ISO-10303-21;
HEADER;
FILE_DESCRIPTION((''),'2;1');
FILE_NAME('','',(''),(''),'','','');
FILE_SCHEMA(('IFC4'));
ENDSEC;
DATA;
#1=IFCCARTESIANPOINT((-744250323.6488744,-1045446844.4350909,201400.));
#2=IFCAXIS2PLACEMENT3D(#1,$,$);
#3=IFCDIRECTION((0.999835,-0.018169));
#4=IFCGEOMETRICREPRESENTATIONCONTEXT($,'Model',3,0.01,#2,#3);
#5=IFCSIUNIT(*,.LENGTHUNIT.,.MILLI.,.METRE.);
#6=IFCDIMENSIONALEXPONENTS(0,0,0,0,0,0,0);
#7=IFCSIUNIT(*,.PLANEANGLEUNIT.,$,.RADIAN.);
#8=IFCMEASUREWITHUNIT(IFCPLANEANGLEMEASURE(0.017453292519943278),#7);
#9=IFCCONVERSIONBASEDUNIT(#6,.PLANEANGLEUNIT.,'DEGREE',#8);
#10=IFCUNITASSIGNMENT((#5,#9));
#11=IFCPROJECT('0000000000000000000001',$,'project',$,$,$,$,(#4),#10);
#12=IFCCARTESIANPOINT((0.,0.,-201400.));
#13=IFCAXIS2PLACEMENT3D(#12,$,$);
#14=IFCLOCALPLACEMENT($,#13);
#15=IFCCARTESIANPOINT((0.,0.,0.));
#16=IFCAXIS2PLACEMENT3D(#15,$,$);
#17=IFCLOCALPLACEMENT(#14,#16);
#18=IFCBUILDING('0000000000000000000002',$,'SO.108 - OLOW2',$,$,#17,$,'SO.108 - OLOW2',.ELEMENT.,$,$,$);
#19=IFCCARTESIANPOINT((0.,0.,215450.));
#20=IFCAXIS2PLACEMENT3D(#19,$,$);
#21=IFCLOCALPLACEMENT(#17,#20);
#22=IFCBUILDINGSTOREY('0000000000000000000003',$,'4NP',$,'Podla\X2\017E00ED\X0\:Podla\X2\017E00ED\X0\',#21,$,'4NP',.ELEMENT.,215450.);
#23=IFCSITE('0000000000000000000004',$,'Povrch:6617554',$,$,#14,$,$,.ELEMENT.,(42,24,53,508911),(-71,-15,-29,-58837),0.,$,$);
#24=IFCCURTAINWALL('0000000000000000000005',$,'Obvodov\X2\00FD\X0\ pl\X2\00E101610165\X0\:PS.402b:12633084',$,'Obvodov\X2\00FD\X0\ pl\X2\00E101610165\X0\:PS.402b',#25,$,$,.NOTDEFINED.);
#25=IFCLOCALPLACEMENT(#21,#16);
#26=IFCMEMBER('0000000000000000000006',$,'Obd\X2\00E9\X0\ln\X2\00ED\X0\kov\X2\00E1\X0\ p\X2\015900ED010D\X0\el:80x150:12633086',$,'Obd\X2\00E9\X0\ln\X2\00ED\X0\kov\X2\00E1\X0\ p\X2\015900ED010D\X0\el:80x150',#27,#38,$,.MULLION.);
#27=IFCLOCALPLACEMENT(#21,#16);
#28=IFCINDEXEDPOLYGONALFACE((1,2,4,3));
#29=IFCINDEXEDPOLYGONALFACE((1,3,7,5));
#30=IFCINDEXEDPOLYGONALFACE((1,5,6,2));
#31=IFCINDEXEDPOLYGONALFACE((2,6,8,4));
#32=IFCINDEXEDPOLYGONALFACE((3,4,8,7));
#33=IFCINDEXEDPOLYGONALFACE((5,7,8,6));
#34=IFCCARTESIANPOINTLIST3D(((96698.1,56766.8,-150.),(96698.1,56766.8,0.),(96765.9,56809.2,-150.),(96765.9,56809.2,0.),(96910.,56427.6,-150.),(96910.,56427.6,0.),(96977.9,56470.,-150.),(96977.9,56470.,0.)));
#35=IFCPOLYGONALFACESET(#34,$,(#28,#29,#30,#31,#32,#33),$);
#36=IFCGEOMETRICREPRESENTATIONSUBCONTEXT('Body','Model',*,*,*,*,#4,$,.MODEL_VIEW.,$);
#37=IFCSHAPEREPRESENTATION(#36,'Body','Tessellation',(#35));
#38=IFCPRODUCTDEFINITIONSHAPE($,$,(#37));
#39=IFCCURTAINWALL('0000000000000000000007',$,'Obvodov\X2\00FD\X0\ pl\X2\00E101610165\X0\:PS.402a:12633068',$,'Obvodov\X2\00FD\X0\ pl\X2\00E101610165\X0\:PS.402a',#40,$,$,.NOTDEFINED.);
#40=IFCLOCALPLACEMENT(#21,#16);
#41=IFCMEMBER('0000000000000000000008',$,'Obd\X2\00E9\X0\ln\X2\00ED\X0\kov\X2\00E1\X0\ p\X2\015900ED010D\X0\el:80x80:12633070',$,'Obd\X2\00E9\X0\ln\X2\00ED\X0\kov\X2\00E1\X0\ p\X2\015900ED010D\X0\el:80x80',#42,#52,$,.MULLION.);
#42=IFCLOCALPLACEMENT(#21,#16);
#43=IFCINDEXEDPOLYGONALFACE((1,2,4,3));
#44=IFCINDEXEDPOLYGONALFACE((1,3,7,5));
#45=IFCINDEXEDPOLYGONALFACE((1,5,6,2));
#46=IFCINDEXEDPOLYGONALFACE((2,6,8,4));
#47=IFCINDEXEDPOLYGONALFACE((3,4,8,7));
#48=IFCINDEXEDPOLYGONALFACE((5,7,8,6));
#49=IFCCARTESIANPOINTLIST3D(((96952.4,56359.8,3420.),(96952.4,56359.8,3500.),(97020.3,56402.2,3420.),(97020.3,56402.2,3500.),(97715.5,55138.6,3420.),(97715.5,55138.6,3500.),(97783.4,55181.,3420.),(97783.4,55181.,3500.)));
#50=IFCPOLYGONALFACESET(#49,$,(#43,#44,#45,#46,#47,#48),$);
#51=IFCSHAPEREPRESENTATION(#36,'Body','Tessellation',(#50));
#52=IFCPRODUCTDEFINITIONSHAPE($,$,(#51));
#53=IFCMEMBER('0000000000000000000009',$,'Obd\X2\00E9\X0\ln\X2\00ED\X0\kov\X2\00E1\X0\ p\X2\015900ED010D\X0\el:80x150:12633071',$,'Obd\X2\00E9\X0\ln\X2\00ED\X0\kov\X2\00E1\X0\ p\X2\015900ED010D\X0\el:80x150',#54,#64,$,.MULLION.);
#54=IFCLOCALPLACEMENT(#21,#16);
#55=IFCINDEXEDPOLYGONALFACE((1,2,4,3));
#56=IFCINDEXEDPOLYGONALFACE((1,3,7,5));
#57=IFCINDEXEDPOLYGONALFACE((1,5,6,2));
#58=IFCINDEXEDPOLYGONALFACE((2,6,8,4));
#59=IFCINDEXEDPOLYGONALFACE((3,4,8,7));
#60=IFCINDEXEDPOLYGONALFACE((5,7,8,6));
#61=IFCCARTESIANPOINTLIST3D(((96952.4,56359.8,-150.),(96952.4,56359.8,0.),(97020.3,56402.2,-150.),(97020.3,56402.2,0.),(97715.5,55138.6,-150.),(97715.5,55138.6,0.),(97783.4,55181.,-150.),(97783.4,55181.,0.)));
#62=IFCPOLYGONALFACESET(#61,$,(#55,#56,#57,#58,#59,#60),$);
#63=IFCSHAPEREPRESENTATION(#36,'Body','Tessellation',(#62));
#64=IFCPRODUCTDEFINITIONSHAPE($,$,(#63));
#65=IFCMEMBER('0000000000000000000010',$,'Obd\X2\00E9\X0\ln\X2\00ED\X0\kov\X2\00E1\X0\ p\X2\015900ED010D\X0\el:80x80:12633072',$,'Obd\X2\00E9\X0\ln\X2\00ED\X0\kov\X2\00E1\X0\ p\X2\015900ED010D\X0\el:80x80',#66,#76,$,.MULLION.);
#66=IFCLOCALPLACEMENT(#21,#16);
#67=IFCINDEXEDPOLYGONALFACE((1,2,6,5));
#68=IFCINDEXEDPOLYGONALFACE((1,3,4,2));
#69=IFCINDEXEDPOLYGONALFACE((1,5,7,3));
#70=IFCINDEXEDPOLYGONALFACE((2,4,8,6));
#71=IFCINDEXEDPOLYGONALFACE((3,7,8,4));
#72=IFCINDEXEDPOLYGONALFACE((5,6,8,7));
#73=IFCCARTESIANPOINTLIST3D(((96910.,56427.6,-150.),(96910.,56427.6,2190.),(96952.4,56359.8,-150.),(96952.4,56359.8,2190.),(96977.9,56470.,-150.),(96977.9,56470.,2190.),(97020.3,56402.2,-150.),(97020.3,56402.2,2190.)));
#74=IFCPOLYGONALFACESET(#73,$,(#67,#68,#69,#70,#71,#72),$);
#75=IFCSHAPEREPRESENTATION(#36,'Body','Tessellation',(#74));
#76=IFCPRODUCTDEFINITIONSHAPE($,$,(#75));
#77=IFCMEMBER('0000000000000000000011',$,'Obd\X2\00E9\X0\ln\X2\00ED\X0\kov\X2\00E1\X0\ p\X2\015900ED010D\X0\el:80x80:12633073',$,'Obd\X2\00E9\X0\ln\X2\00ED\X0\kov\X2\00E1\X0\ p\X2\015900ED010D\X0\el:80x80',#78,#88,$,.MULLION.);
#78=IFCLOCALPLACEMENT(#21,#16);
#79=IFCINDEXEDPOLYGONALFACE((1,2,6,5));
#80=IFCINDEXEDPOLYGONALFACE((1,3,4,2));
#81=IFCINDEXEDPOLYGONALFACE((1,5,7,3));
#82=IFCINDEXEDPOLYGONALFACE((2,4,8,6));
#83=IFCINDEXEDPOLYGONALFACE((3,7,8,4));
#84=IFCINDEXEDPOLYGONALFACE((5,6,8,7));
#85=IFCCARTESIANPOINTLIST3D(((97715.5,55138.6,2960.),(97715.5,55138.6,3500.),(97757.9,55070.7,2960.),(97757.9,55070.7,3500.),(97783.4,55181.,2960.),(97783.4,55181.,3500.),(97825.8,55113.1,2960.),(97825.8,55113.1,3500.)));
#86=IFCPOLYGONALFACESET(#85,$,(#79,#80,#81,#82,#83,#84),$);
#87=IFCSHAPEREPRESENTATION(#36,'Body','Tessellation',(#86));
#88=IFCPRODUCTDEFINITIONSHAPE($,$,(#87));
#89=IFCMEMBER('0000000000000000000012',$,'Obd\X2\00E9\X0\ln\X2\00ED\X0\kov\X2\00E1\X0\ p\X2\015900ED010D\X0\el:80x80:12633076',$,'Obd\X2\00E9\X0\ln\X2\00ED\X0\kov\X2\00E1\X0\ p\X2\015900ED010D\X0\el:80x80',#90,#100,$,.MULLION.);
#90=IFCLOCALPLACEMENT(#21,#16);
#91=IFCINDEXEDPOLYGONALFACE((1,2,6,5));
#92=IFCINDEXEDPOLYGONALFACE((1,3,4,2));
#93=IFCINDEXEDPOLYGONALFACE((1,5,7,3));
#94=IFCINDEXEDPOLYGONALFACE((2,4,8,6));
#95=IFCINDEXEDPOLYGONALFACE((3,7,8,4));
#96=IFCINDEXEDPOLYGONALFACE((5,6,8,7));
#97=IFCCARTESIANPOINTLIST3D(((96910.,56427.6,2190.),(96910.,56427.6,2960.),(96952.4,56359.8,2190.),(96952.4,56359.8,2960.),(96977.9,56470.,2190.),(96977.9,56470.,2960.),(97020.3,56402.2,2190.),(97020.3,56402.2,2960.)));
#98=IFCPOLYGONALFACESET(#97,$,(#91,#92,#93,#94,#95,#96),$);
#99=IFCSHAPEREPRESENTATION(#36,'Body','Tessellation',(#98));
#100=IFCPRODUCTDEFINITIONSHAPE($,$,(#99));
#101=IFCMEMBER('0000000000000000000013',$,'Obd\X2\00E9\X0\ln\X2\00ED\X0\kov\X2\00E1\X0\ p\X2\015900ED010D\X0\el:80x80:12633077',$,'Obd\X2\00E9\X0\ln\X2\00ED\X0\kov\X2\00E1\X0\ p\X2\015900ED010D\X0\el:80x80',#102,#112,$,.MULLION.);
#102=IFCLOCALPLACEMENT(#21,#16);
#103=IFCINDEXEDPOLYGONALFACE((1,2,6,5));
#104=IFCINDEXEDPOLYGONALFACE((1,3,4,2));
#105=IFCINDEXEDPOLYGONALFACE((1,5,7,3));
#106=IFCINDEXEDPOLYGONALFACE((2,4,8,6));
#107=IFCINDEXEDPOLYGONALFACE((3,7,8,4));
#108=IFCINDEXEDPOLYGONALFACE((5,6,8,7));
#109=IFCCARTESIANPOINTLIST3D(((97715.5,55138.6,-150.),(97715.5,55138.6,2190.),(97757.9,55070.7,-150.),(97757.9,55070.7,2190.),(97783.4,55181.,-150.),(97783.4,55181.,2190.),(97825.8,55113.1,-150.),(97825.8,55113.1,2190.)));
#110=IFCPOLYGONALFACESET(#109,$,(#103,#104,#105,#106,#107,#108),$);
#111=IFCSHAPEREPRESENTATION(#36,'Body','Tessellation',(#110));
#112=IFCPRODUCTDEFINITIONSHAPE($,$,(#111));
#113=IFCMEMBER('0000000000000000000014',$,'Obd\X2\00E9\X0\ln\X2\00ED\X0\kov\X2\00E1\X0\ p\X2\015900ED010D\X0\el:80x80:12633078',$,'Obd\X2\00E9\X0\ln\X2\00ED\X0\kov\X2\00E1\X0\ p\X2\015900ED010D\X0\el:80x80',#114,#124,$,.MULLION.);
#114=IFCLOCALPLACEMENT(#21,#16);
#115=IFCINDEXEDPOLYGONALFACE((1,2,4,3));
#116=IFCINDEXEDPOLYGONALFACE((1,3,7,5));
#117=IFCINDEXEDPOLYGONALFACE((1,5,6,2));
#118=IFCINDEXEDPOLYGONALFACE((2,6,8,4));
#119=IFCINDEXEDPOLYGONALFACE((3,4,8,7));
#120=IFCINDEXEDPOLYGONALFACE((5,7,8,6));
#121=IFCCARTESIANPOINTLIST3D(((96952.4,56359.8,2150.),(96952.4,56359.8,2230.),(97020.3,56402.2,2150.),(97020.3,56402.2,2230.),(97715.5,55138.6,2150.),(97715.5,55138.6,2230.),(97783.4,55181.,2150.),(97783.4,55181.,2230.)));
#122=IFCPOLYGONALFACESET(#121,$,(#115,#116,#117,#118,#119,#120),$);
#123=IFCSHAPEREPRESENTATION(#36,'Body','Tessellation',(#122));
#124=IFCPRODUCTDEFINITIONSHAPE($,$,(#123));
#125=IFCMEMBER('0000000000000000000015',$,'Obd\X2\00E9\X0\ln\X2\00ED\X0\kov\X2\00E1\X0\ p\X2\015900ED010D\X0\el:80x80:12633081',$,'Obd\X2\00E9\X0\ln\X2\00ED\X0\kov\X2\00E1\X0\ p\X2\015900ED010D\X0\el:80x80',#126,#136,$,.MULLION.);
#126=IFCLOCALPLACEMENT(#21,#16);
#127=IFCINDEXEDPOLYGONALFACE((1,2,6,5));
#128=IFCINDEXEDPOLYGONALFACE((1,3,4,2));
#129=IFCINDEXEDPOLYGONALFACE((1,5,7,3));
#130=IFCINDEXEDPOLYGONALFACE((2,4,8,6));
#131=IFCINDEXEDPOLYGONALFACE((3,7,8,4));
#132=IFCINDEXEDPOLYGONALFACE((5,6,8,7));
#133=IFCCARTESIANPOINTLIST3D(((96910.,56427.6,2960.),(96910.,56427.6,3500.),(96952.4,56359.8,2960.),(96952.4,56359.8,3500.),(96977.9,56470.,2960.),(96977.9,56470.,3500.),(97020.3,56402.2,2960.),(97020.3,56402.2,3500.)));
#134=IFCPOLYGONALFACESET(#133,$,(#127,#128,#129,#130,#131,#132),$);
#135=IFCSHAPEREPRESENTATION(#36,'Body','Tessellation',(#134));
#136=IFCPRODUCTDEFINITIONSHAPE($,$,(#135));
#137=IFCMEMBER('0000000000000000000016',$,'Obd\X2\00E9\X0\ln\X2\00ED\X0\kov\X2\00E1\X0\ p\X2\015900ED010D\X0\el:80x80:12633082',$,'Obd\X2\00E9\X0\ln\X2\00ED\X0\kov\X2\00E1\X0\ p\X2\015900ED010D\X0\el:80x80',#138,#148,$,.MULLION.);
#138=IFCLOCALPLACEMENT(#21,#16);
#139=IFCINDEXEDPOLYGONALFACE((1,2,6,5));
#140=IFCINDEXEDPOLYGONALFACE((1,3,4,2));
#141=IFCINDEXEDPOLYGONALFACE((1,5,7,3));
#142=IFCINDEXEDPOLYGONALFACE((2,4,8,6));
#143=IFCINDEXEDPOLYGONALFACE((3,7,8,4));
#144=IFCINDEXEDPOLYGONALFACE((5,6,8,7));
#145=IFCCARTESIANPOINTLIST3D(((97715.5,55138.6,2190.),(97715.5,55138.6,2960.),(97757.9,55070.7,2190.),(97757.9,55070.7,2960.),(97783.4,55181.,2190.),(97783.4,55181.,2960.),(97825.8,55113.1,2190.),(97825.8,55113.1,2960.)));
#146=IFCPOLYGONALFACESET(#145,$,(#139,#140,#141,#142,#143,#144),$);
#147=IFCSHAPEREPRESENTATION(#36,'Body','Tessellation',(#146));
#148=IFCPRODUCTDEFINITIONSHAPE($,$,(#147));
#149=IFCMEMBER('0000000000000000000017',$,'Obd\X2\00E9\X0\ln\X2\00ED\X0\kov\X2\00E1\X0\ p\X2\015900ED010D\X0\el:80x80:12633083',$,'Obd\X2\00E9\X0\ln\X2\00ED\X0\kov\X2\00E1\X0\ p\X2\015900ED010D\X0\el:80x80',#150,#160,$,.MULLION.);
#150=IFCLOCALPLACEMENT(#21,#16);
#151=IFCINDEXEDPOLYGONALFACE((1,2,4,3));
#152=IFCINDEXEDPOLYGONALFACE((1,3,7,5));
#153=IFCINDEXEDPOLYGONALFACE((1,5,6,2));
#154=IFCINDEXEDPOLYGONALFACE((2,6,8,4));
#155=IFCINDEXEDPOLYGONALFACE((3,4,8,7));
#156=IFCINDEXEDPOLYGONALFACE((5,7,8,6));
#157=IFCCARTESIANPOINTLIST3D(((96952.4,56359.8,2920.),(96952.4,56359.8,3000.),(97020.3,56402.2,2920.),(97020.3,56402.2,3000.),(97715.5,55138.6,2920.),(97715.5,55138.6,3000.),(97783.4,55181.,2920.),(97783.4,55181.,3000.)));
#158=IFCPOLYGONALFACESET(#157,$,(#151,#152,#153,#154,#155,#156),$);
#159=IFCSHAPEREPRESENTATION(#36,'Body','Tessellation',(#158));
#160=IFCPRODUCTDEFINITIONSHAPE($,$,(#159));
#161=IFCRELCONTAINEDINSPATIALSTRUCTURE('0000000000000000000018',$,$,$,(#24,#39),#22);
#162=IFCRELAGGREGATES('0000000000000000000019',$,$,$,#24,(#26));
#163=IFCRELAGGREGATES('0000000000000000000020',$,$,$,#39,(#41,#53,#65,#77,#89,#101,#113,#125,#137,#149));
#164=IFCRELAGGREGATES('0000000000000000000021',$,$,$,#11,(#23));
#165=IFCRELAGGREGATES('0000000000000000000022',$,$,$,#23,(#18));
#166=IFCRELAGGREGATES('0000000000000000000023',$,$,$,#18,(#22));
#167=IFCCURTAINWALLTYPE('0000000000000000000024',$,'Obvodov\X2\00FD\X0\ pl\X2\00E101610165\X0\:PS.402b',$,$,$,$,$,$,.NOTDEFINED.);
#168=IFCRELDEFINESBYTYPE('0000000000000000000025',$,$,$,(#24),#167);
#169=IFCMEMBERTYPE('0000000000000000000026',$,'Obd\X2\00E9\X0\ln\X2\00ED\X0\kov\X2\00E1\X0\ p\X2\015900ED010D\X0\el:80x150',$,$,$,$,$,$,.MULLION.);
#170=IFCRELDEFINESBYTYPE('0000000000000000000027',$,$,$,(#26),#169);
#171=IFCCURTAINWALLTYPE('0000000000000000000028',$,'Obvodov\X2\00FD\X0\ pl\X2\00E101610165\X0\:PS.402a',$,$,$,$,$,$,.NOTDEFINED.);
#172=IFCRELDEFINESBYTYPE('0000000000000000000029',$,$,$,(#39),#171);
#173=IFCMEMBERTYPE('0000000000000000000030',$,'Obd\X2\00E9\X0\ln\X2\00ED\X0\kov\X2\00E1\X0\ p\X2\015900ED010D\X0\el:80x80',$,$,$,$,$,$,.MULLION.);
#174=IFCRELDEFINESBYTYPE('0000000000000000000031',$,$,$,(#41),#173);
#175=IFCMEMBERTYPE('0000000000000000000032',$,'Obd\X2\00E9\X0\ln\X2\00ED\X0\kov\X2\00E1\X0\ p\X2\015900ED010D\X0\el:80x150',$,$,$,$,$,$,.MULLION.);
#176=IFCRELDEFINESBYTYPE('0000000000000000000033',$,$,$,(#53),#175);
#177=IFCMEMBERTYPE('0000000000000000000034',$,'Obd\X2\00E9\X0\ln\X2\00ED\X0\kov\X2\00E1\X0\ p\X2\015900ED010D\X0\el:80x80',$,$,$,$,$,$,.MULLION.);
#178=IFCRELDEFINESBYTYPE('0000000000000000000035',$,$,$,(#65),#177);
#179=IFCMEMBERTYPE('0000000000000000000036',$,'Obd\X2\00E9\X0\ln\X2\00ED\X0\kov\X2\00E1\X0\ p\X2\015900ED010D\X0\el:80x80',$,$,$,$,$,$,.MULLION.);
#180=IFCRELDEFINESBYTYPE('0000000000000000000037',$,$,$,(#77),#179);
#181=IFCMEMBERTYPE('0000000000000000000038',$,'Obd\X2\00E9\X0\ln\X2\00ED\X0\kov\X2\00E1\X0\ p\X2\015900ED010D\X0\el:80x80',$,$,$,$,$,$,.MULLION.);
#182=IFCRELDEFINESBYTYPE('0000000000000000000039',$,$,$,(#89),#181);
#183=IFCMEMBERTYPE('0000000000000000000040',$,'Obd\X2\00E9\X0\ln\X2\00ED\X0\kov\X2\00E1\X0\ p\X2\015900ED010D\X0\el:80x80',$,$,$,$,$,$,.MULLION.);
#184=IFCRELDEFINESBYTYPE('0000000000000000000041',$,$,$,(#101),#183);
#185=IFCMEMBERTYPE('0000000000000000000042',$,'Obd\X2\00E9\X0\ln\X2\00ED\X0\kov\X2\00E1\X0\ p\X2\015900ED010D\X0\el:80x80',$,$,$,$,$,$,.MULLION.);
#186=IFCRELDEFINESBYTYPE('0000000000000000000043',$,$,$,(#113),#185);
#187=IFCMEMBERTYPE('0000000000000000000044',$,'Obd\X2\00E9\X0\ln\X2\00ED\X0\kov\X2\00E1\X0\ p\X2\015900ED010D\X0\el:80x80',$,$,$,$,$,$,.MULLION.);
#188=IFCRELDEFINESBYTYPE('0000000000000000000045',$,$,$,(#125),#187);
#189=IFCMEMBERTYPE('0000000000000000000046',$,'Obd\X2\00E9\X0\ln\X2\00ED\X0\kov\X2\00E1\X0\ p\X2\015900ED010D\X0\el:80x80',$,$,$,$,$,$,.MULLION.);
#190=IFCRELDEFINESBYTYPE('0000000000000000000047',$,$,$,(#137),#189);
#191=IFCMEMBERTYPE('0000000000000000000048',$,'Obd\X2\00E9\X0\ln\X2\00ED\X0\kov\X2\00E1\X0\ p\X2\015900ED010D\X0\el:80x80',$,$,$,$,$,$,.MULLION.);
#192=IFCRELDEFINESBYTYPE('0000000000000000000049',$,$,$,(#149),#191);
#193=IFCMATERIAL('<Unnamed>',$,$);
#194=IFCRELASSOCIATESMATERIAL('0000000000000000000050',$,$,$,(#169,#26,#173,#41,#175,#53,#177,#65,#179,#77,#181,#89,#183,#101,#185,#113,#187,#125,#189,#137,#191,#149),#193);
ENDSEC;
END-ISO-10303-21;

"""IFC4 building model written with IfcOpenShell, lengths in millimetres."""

from ifc_helpers import new_model, entity, si_unit, converted_unit, direction, frame, origin, place, context, subcontext, project, spatial, indexed_curve, outline, extrude, source, transform, mapped, material, type_object, type_shapes, element, aggregate, save


model = new_model("IFC4")

# Units and contexts
model_context = context("Model", 3, precision=0.01, world=frame((-744250323.6488744, -1045446844.4350909, 201400.0)), true_north=direction((0.999835, -0.018169)))
body_context = subcontext(model_context, "Body", "Model", "MODEL_VIEW")
ifc_project = project(units=[si_unit("LENGTHUNIT", "METRE", prefix="MILLI"), converted_unit("PLANEANGLEUNIT", "DEGREE", entity("IfcPlaneAngleMeasure", 0.017453292519943278), si_unit("PLANEANGLEUNIT", "RADIAN"), dimensions=[0, 0, 0, 0, 0, 0, 0])], contexts=[model_context])

# Site, building, storey
site_placement = place(None, frame((0.0, 0.0, -201400.0)))
site = spatial("IfcSite", under=ifc_project, at=site_placement, Name="Povrch:6617554", CompositionType="ELEMENT", RefLatitude=(42, 24, 53, 508911), RefLongitude=(-71, -15, -29, -58837), RefElevation=0.0)
building_placement = place(site_placement, origin())
building = spatial("IfcBuilding", under=site, at=building_placement, Name="SO.108 - OLOW2", LongName="SO.108 - OLOW2", CompositionType="ELEMENT")
storey_placement = place(building_placement, frame((0.0, 0.0, 215450.0)))
storey = spatial("IfcBuildingStorey", under=building, at=storey_placement, Name="4NP", ObjectType="Podlaží:Podlaží", LongName="4NP", CompositionType="ELEMENT", Elevation=215450.0)

# Shared definitions
ifc_material_1 = material(Name="<Unnamed>")

# Curtain wall, member
curtain_wall_type_1 = type_object("IfcCurtainWallType", Name="Obvodový plášť:PS.402b", PredefinedType="NOTDEFINED")
curtain_wall_1_placement = place(storey_placement, frame((0.0, 0.0, -215450.0)))
curtain_wall_1 = element("IfcCurtainWall", 1, at=curtain_wall_1_placement, inside=storey, type_object=curtain_wall_type_1, Name="Obvodový plášť:PS.402b:12633084", ObjectType="Obvodový plášť:PS.402b", PredefinedType="NOTDEFINED")
member_type_1 = type_object("IfcMemberType", Name="Obdélníková příčel:80x150", PredefinedType="MULLION", material=ifc_material_1)
shared_shape_1 = source(origin(), body_context, "Body", "SweptSolid", [
    extrude(outline(indexed_curve([(-75.0, -40.0), (75.0, -40.0), (75.0, 40.0), (-75.0, 40.0), (-75.0, -40.0)], self_intersect=False)), frame((-75.0, 0.0, -400.0), z_axis=(0.0, 0.0, 1.0), x_axis=(-1.0, 0.0, 0.0)), (0.0, 0.0, 1.0), 400.0),
])
type_shapes(member_type_1, [shared_shape_1])
member_1_placement = place(curtain_wall_1_placement, frame((96732.0, 56788.0, 215300.0), z_axis=(-0.529919, 0.848048, 0.0), x_axis=(0.0, 0.0, -1.0)))
member_1 = element("IfcMember", 2, at=member_1_placement, type_object=member_type_1, material=ifc_material_1, Name="Obdélníková příčel:80x150:12633086", ObjectType="Obdélníková příčel:80x150", PredefinedType="MULLION", context=body_context, shape_type="MappedRepresentation", body=[
    mapped(shared_shape_1, transform((0.0, 0.0, 0.0), scale=1.0)),
])

# Curtain wall, members
curtain_wall_type_2 = type_object("IfcCurtainWallType", Name="Obvodový plášť:PS.402a", PredefinedType="NOTDEFINED")
curtain_wall_2_placement = place(storey_placement, frame((0.0, 0.0, -215450.0)))
curtain_wall_2 = element("IfcCurtainWall", 3, at=curtain_wall_2_placement, inside=storey, type_object=curtain_wall_type_2, Name="Obvodový plášť:PS.402a:12633068", ObjectType="Obvodový plášť:PS.402a", PredefinedType="NOTDEFINED")
member_type_2 = type_object("IfcMemberType", Name="Obdélníková příčel:80x80", PredefinedType="MULLION", material=ifc_material_1)
shared_shape_2 = source(origin(), body_context, "Body", "SweptSolid", [
    extrude(outline(indexed_curve([(-40.0, -40.0), (40.0, -40.0), (40.0, 40.0), (-40.0, 40.0), (-40.0, -40.0)], self_intersect=False)), frame((-40.0, 0.0, -1440.0), z_axis=(0.0, 0.0, 1.0), x_axis=(-1.0, 0.0, 0.0)), (0.0, 0.0, 1.0), 1440.0),
])
type_shapes(member_type_2, [shared_shape_2])
member_2_placement = place(curtain_wall_2_placement, frame((96986.4, 56381.0, 218950.0), z_axis=(-0.529919, 0.848048, 0.0), x_axis=(0.0, 0.0, 1.0)))
member_2 = element("IfcMember", 4, at=member_2_placement, type_object=member_type_2, material=ifc_material_1, Name="Obdélníková příčel:80x80:12633070", ObjectType="Obdélníková příčel:80x80", PredefinedType="MULLION", context=body_context, shape_type="MappedRepresentation", body=[
    mapped(shared_shape_2, transform((0.0, 0.0, 0.0), scale=1.0)),
])
member_type_3 = type_object("IfcMemberType", Name="Obdélníková příčel:80x150", PredefinedType="MULLION", material=ifc_material_1)
shared_shape_3 = source(origin(), body_context, "Body", "SweptSolid", [
    extrude(outline(indexed_curve([(-75.0, -40.0), (75.0, -40.0), (75.0, 40.0), (-75.0, 40.0), (-75.0, -40.0)], self_intersect=False)), frame((-75.0, 0.0, -1440.0), z_axis=(0.0, 0.0, 1.0), x_axis=(-1.0, 0.0, 0.0)), (0.0, 0.0, 1.0), 1440.0),
])
type_shapes(member_type_3, [shared_shape_3])
member_3_placement = place(curtain_wall_2_placement, frame((97749.4, 55159.8, 215300.0), z_axis=(0.529919, -0.848048, 0.0), x_axis=(0.0, 0.0, -1.0)))
member_3 = element("IfcMember", 5, at=member_3_placement, type_object=member_type_3, material=ifc_material_1, Name="Obdélníková příčel:80x150:12633071", ObjectType="Obdélníková příčel:80x150", PredefinedType="MULLION", context=body_context, shape_type="MappedRepresentation", body=[
    mapped(shared_shape_3, transform((0.0, 0.0, 0.0), scale=1.0)),
])
member_type_4 = type_object("IfcMemberType", Name="Obdélníková příčel:80x80", PredefinedType="MULLION", material=ifc_material_1)
shared_shape_4 = source(origin(), body_context, "Body", "SweptSolid", [
    extrude(outline(indexed_curve([(-40.0, -40.0), (40.0, -40.0), (40.0, 40.0), (-40.0, 40.0), (-40.0, -40.0)], self_intersect=False)), frame((-40.0, 0.0, -2340.0), z_axis=(0.0, 0.0, 1.0), x_axis=(-1.0, 0.0, 0.0)), (0.0, 0.0, 1.0), 2340.0),
])
type_shapes(member_type_4, [shared_shape_4])
member_4_placement = place(curtain_wall_2_placement, frame((96944.0, 56448.8, 215300.0), z_axis=(0.0, 0.0, -1.0), x_axis=(-0.529919, 0.848048, 0.0)))
member_4 = element("IfcMember", 6, at=member_4_placement, type_object=member_type_4, material=ifc_material_1, Name="Obdélníková příčel:80x80:12633072", ObjectType="Obdélníková příčel:80x80", PredefinedType="MULLION", context=body_context, shape_type="MappedRepresentation", body=[
    mapped(shared_shape_4, transform((0.0, 0.0, 0.0), scale=1.0)),
])
member_type_5 = type_object("IfcMemberType", Name="Obdélníková příčel:80x80", PredefinedType="MULLION", material=ifc_material_1)
shared_shape_5 = source(origin(), body_context, "Body", "SweptSolid", [
    extrude(outline(indexed_curve([(-40.0, -40.0), (40.0, -40.0), (40.0, 40.0), (-40.0, 40.0), (-40.0, -40.0)], self_intersect=False)), frame((-40.0, 0.0, -540.0), z_axis=(0.0, 0.0, 1.0), x_axis=(-1.0, 0.0, 0.0)), (0.0, 0.0, 1.0), 540.0),
])
type_shapes(member_type_5, [shared_shape_5])
member_5_placement = place(curtain_wall_2_placement, frame((97791.8, 55091.9, 218950.0), z_axis=(0.0, 0.0, 1.0), x_axis=(0.529919, -0.848048, 0.0)))
member_5 = element("IfcMember", 7, at=member_5_placement, type_object=member_type_5, material=ifc_material_1, Name="Obdélníková příčel:80x80:12633073", ObjectType="Obdélníková příčel:80x80", PredefinedType="MULLION", context=body_context, shape_type="MappedRepresentation", body=[
    mapped(shared_shape_5, transform((0.0, 0.0, 0.0), scale=1.0)),
])
member_type_6 = type_object("IfcMemberType", Name="Obdélníková příčel:80x80", PredefinedType="MULLION", material=ifc_material_1)
shared_shape_6 = source(origin(), body_context, "Body", "SweptSolid", [
    extrude(outline(indexed_curve([(-40.0, -40.0), (40.0, -40.0), (40.0, 40.0), (-40.0, 40.0), (-40.0, -40.0)], self_intersect=False)), frame((-40.0, 0.0, -770.0), z_axis=(0.0, 0.0, 1.0), x_axis=(-1.0, 0.0, 0.0)), (0.0, 0.0, 1.0), 770.0),
])
type_shapes(member_type_6, [shared_shape_6])
member_6_placement = place(curtain_wall_2_placement, frame((96944.0, 56448.8, 217640.0), z_axis=(0.0, 0.0, -1.0), x_axis=(-0.529919, 0.848048, 0.0)))
member_6 = element("IfcMember", 8, at=member_6_placement, type_object=member_type_6, material=ifc_material_1, Name="Obdélníková příčel:80x80:12633076", ObjectType="Obdélníková příčel:80x80", PredefinedType="MULLION", context=body_context, shape_type="MappedRepresentation", body=[
    mapped(shared_shape_6, transform((0.0, 0.0, 0.0), scale=1.0)),
])
member_type_7 = type_object("IfcMemberType", Name="Obdélníková příčel:80x80", PredefinedType="MULLION", material=ifc_material_1)
shared_shape_7 = source(origin(), body_context, "Body", "SweptSolid", [
    extrude(outline(indexed_curve([(-40.0, -40.0), (40.0, -40.0), (40.0, 40.0), (-40.0, 40.0), (-40.0, -40.0)], self_intersect=False)), frame((-40.0, 0.0, -2340.0), z_axis=(0.0, 0.0, 1.0), x_axis=(-1.0, 0.0, 0.0)), (0.0, 0.0, 1.0), 2340.0),
])
type_shapes(member_type_7, [shared_shape_7])
member_7_placement = place(curtain_wall_2_placement, frame((97791.8, 55091.9, 217640.0), z_axis=(0.0, 0.0, 1.0), x_axis=(0.529919, -0.848048, 0.0)))
member_7 = element("IfcMember", 9, at=member_7_placement, type_object=member_type_7, material=ifc_material_1, Name="Obdélníková příčel:80x80:12633077", ObjectType="Obdélníková příčel:80x80", PredefinedType="MULLION", context=body_context, shape_type="MappedRepresentation", body=[
    mapped(shared_shape_7, transform((0.0, 0.0, 0.0), scale=1.0)),
])
member_type_8 = type_object("IfcMemberType", Name="Obdélníková příčel:80x80", PredefinedType="MULLION", material=ifc_material_1)
shared_shape_8 = source(origin(), body_context, "Body", "SweptSolid", [
    extrude(outline(indexed_curve([(-40.0, -40.0), (40.0, -40.0), (40.0, 40.0), (-40.0, 40.0), (-40.0, -40.0)], self_intersect=False)), frame((0.0, 0.0, -1440.0), z_axis=(0.0, 0.0, 1.0), x_axis=(-1.0, 0.0, 0.0)), (0.0, 0.0, 1.0), 1440.0),
])
type_shapes(member_type_8, [shared_shape_8])
member_8_placement = place(curtain_wall_2_placement, frame((96986.4, 56381.0, 217640.0), z_axis=(-0.529919, 0.848048, 0.0), x_axis=(0.0, 0.0, 1.0)))
member_8 = element("IfcMember", 10, at=member_8_placement, type_object=member_type_8, material=ifc_material_1, Name="Obdélníková příčel:80x80:12633078", ObjectType="Obdélníková příčel:80x80", PredefinedType="MULLION", context=body_context, shape_type="MappedRepresentation", body=[
    mapped(shared_shape_8, transform((0.0, 0.0, 0.0), scale=1.0)),
])
member_type_9 = type_object("IfcMemberType", Name="Obdélníková příčel:80x80", PredefinedType="MULLION", material=ifc_material_1)
shared_shape_9 = source(origin(), body_context, "Body", "SweptSolid", [
    extrude(outline(indexed_curve([(-40.0, -40.0), (40.0, -40.0), (40.0, 40.0), (-40.0, 40.0), (-40.0, -40.0)], self_intersect=False)), frame((-40.0, 0.0, -540.0), z_axis=(0.0, 0.0, 1.0), x_axis=(-1.0, 0.0, 0.0)), (0.0, 0.0, 1.0), 540.0),
])
type_shapes(member_type_9, [shared_shape_9])
member_9_placement = place(curtain_wall_2_placement, frame((96944.0, 56448.8, 218410.0), z_axis=(0.0, 0.0, -1.0), x_axis=(-0.529919, 0.848048, 0.0)))
member_9 = element("IfcMember", 11, at=member_9_placement, type_object=member_type_9, material=ifc_material_1, Name="Obdélníková příčel:80x80:12633081", ObjectType="Obdélníková příčel:80x80", PredefinedType="MULLION", context=body_context, shape_type="MappedRepresentation", body=[
    mapped(shared_shape_9, transform((0.0, 0.0, 0.0), scale=1.0)),
])
member_type_10 = type_object("IfcMemberType", Name="Obdélníková příčel:80x80", PredefinedType="MULLION", material=ifc_material_1)
shared_shape_10 = source(origin(), body_context, "Body", "SweptSolid", [
    extrude(outline(indexed_curve([(-40.0, -40.0), (40.0, -40.0), (40.0, 40.0), (-40.0, 40.0), (-40.0, -40.0)], self_intersect=False)), frame((-40.0, 0.0, -770.0), z_axis=(0.0, 0.0, 1.0), x_axis=(-1.0, 0.0, 0.0)), (0.0, 0.0, 1.0), 770.0),
])
type_shapes(member_type_10, [shared_shape_10])
member_10_placement = place(curtain_wall_2_placement, frame((97791.8, 55091.9, 218410.0), z_axis=(0.0, 0.0, 1.0), x_axis=(0.529919, -0.848048, 0.0)))
member_10 = element("IfcMember", 12, at=member_10_placement, type_object=member_type_10, material=ifc_material_1, Name="Obdélníková příčel:80x80:12633082", ObjectType="Obdélníková příčel:80x80", PredefinedType="MULLION", context=body_context, shape_type="MappedRepresentation", body=[
    mapped(shared_shape_10, transform((0.0, 0.0, 0.0), scale=1.0)),
])
member_type_11 = type_object("IfcMemberType", Name="Obdélníková příčel:80x80", PredefinedType="MULLION", material=ifc_material_1)
shared_shape_11 = source(origin(), body_context, "Body", "SweptSolid", [
    extrude(outline(indexed_curve([(-40.0, -40.0), (40.0, -40.0), (40.0, 40.0), (-40.0, 40.0), (-40.0, -40.0)], self_intersect=False)), frame((0.0, 0.0, -1440.0), z_axis=(0.0, 0.0, 1.0), x_axis=(-1.0, 0.0, 0.0)), (0.0, 0.0, 1.0), 1440.0),
])
type_shapes(member_type_11, [shared_shape_11])
member_11_placement = place(curtain_wall_2_placement, frame((96986.4, 56381.0, 218410.0), z_axis=(-0.529919, 0.848048, 0.0), x_axis=(0.0, 0.0, 1.0)))
member_11 = element("IfcMember", 13, at=member_11_placement, type_object=member_type_11, material=ifc_material_1, Name="Obdélníková příčel:80x80:12633083", ObjectType="Obdélníková příčel:80x80", PredefinedType="MULLION", context=body_context, shape_type="MappedRepresentation", body=[
    mapped(shared_shape_11, transform((0.0, 0.0, 0.0), scale=1.0)),
])

aggregate(curtain_wall_1, [member_1])

aggregate(curtain_wall_2, [member_2, member_3, member_4, member_5, member_6, member_7, member_8, member_9, member_10, member_11])

save(model, "model.ifc")
